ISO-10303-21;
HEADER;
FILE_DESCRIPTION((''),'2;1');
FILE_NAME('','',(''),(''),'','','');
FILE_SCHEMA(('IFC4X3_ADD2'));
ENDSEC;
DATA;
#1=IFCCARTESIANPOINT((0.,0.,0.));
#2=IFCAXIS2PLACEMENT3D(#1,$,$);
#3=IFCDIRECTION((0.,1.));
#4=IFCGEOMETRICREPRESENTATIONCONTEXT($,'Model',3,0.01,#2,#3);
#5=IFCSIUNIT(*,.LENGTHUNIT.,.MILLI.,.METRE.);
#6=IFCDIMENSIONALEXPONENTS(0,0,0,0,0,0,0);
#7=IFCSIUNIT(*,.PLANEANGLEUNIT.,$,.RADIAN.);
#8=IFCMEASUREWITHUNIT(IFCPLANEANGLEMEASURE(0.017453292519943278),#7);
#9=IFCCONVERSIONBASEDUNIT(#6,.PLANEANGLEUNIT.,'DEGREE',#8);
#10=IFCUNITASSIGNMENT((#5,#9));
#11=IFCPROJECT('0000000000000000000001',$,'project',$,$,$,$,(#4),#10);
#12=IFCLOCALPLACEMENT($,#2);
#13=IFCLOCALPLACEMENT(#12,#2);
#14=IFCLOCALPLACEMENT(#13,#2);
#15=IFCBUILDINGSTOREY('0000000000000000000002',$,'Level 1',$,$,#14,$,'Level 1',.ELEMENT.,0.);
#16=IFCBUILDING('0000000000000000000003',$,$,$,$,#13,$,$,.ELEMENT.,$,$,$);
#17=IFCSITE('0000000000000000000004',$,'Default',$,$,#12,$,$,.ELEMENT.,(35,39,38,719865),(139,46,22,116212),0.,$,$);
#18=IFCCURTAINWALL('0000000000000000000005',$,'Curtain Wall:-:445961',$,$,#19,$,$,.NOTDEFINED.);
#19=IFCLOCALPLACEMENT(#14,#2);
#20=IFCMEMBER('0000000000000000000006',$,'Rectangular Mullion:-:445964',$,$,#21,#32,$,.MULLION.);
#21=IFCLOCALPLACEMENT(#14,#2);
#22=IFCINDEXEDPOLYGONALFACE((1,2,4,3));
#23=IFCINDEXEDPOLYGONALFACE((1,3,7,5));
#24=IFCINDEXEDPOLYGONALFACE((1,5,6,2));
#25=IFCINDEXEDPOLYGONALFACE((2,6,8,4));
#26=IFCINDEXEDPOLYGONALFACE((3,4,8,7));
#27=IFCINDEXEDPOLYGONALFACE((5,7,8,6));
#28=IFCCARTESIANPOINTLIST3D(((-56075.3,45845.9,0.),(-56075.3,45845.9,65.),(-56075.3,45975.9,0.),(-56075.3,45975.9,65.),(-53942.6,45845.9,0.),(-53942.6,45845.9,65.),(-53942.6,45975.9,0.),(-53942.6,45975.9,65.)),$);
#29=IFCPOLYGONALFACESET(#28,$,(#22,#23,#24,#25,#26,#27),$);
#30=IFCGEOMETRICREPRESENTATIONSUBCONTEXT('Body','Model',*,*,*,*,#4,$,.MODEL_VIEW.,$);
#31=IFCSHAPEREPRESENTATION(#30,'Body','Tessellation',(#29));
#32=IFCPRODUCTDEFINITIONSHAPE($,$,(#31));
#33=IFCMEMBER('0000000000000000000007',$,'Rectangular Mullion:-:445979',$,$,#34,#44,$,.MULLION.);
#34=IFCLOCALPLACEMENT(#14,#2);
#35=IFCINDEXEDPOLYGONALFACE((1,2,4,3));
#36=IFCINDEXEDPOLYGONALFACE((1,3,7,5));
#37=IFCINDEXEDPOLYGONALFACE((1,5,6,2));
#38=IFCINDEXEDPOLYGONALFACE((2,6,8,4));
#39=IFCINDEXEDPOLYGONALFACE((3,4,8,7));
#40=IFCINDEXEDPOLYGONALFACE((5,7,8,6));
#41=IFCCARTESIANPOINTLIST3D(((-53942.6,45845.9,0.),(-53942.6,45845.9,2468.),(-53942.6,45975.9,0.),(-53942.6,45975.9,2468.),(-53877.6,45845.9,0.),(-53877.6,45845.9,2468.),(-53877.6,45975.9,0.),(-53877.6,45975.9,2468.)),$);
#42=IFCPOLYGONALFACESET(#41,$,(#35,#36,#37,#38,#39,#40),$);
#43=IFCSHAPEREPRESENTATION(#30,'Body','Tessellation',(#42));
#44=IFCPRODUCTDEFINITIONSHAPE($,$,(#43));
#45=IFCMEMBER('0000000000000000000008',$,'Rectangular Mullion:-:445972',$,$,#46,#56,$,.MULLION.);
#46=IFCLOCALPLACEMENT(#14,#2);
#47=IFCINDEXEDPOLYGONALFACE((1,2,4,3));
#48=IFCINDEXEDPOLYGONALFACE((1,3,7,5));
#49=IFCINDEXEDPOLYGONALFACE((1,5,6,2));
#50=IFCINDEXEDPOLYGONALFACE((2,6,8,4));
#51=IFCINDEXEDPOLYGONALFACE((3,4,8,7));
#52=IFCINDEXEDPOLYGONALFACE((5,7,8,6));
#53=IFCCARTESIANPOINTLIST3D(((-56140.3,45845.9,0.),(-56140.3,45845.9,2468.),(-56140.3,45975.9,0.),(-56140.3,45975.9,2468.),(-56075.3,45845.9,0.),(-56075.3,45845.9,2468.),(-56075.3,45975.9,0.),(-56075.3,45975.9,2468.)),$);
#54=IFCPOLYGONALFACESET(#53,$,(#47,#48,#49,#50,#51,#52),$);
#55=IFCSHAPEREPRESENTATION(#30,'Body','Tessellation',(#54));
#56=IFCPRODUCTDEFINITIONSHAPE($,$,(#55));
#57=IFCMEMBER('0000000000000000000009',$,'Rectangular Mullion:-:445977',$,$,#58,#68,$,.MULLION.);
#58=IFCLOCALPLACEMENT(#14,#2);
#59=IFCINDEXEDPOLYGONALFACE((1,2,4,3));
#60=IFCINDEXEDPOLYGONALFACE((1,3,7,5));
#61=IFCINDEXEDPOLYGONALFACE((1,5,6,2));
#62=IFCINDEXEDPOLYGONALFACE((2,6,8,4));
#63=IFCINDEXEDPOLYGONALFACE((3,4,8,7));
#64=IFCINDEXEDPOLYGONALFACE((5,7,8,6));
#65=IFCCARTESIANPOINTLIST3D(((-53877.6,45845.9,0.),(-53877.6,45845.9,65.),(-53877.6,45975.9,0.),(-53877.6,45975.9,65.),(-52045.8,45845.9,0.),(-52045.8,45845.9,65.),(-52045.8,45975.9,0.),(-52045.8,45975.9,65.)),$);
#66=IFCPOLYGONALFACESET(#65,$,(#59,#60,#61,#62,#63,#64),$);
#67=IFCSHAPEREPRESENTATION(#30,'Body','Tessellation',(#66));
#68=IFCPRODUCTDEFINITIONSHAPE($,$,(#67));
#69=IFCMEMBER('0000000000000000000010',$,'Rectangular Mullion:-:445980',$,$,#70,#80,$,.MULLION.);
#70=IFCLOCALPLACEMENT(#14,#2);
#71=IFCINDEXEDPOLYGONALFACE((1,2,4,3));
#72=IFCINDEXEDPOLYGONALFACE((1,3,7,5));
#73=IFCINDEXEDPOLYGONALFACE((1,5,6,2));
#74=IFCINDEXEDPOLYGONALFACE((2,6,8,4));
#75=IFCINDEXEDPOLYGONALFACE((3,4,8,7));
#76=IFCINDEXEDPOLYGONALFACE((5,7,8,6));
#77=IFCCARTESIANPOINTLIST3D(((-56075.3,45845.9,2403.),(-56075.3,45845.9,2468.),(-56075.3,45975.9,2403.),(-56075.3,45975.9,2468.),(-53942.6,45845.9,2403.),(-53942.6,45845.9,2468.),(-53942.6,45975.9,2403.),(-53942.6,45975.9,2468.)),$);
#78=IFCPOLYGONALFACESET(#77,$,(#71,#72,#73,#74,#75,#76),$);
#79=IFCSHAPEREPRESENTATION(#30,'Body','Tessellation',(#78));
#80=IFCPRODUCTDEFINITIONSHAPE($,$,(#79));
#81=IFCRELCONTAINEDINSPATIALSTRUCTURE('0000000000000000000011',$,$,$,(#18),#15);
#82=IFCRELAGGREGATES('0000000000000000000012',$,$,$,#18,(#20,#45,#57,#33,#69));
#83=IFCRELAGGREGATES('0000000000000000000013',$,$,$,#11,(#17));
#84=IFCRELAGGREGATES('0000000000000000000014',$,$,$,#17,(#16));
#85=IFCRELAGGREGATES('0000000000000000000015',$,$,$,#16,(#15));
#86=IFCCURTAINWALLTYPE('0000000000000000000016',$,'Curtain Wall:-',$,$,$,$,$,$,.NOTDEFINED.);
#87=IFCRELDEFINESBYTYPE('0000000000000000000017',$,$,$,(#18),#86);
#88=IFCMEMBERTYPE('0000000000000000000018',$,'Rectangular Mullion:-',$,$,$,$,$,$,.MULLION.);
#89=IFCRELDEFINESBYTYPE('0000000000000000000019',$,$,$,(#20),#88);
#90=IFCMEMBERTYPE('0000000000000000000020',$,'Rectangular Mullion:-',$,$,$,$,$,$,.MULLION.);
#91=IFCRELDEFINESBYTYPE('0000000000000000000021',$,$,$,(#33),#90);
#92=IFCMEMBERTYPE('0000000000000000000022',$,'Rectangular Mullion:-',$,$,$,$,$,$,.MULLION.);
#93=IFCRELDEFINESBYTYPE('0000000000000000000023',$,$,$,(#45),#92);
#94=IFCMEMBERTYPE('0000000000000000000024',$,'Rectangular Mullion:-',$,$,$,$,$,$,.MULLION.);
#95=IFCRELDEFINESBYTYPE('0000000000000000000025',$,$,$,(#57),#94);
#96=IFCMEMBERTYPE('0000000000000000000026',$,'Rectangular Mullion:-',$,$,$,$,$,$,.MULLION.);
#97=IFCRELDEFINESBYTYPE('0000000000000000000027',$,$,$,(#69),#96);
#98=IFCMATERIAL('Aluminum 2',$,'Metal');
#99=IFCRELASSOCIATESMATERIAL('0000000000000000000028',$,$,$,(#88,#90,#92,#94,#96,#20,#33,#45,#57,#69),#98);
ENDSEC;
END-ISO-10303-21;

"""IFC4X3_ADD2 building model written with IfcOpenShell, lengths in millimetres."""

from ifc_helpers import new_model, entity, si_unit, converted_unit, direction, frame, frame_2d, origin, origin_2d_with_axis, place, context, subcontext, project, spatial, rectangle, extrude, source, transform, mapped, material, material_profile, profile_set, profile_usage, type_object, type_shapes, element, aggregate, save


model = new_model("IFC4X3_ADD2")

# Units and contexts
model_context = context("Model", 3, precision=0.01, world=origin(), true_north=direction((0.0, 1.0)))
body_context = subcontext(model_context, "Body", "Model", "MODEL_VIEW")
ifc_project = project(units=[si_unit("LENGTHUNIT", "METRE", prefix="MILLI"), converted_unit("PLANEANGLEUNIT", "DEGREE", entity("IfcPlaneAngleMeasure", 0.017453292519943278), si_unit("PLANEANGLEUNIT", "RADIAN"), dimensions=[0, 0, 0, 0, 0, 0, 0])], contexts=[model_context])

# Site, building, storey
site_placement = place(None, origin())
site = spatial("IfcSite", under=ifc_project, at=site_placement, Name="Default", CompositionType="ELEMENT", RefLatitude=(35, 39, 38, 719865), RefLongitude=(139, 46, 22, 116212), RefElevation=0.0)
building_placement = place(site_placement, origin())
building = spatial("IfcBuilding", under=site, at=building_placement, CompositionType="ELEMENT")
storey_placement = place(building_placement, origin())
storey = spatial("IfcBuildingStorey", under=building, at=storey_placement, Name="Level 1", LongName="Level 1", CompositionType="ELEMENT", Elevation=0.0)

# Curtain wall, members
curtain_wall_type = type_object("IfcCurtainWallType", Name="Curtain Wall:-", PredefinedType="NOTDEFINED")
curtain_wall_placement = place(storey_placement, origin())
curtain_wall = element("IfcCurtainWall", 1, at=curtain_wall_placement, inside=storey, type_object=curtain_wall_type, Name="Curtain Wall:-:445961", PredefinedType="NOTDEFINED")
ifc_material_1 = material(Name="Aluminum 2", Category="Metal")
ifc_material_profile = material_profile(ifc_material_1, rectangle(XDim=65.0, YDim=130.0, at=origin_2d_with_axis()), Name="-")
ifc_profile_set = profile_set([ifc_material_profile], Name="-")
ifc_profile_usage = profile_usage(ifc_profile_set)
member_type_1 = type_object("IfcMemberType", Name="Rectangular Mullion:-", PredefinedType="MULLION", material=ifc_profile_set)
shared_shape_1 = source(origin(), body_context, "Body", "SweptSolid", [
    extrude(rectangle(XDim=65.0, YDim=130.0, at=origin_2d_with_axis()), frame((-32.5, 0.0, -2132.6), z_axis=(0.0, 0.0, 1.0), x_axis=(-1.0, 0.0, 0.0)), (0.0, 0.0, 1.0), 2132.6),
])
type_shapes(member_type_1, [shared_shape_1])
member_1_placement = place(curtain_wall_placement, frame((-56075.3, 45910.9, 0.0), z_axis=(-1.0, 0.0, 0.0), x_axis=(0.0, 0.0, -1.0)))
member_1 = element("IfcMember", 2, at=member_1_placement, type_object=member_type_1, material=ifc_profile_usage, Name="Rectangular Mullion:-:445964", PredefinedType="MULLION", context=body_context, shape_type="MappedRepresentation", body=[
    mapped(shared_shape_1, transform((0.0, 0.0, 0.0), scale=1.0)),
])
member_type_2 = type_object("IfcMemberType", Name="Rectangular Mullion:-", PredefinedType="MULLION", material=ifc_profile_set)
shared_shape_2 = source(origin(), body_context, "Body", "SweptSolid", [
    extrude(rectangle(XDim=65.0, YDim=130.0, at=frame_2d((0.0, 0.0), x_axis=(1.0, 0.0))), frame((0.0, 0.0, -2468.0), z_axis=(0.0, 0.0, 1.0), x_axis=(-1.0, 0.0, 0.0)), (0.0, 0.0, 1.0), 2468.0),
])
type_shapes(member_type_2, [shared_shape_2])
member_2_placement = place(curtain_wall_placement, frame((-53910.1, 45910.9, 0.0), z_axis=(0.0, 0.0, -1.0), x_axis=(1.0, 0.0, 0.0)))
member_2 = element("IfcMember", 3, at=member_2_placement, type_object=member_type_2, material=ifc_profile_usage, Name="Rectangular Mullion:-:445979", PredefinedType="MULLION", context=body_context, shape_type="MappedRepresentation", body=[
    mapped(shared_shape_2, transform((0.0, 0.0, 0.0), scale=1.0)),
])
member_type_3 = type_object("IfcMemberType", Name="Rectangular Mullion:-", PredefinedType="MULLION", material=ifc_profile_set)
shared_shape_3 = source(origin(), body_context, "Body", "SweptSolid", [
    extrude(rectangle(XDim=65.0, YDim=130.0, at=frame_2d((0.0, 0.0), x_axis=(1.0, 0.0))), frame((-32.5, 0.0, -2468.0), z_axis=(0.0, 0.0, 1.0), x_axis=(-1.0, 0.0, 0.0)), (0.0, 0.0, 1.0), 2468.0),
])
type_shapes(member_type_3, [shared_shape_3])
member_3_placement = place(curtain_wall_placement, frame((-56140.3, 45910.9, 2468.0), z_axis=(0.0, 0.0, 1.0), x_axis=(-1.0, 0.0, 0.0)))
member_3 = element("IfcMember", 4, at=member_3_placement, type_object=member_type_3, material=ifc_profile_usage, Name="Rectangular Mullion:-:445972", PredefinedType="MULLION", context=body_context, shape_type="MappedRepresentation", body=[
    mapped(shared_shape_3, transform((0.0, 0.0, 0.0), scale=1.0)),
])
member_type_4 = type_object("IfcMemberType", Name="Rectangular Mullion:-", PredefinedType="MULLION", material=ifc_profile_set)
shared_shape_4 = source(origin(), body_context, "Body", "SweptSolid", [
    extrude(rectangle(XDim=65.0, YDim=130.0, at=frame_2d((0.0, 0.0), x_axis=(1.0, 0.0))), frame((-32.5, 0.0, -1831.9), z_axis=(0.0, 0.0, 1.0), x_axis=(-1.0, 0.0, 0.0)), (0.0, 0.0, 1.0), 1831.9),
])
type_shapes(member_type_4, [shared_shape_4])
member_4_placement = place(curtain_wall_placement, frame((-53877.6, 45910.9, 0.0), z_axis=(-1.0, 0.0, 0.0), x_axis=(0.0, 0.0, -1.0)))
member_4 = element("IfcMember", 5, at=member_4_placement, type_object=member_type_4, material=ifc_profile_usage, Name="Rectangular Mullion:-:445977", PredefinedType="MULLION", context=body_context, shape_type="MappedRepresentation", body=[
    mapped(shared_shape_4, transform((0.0, 0.0, 0.0), scale=1.0)),
])
member_type_5 = type_object("IfcMemberType", Name="Rectangular Mullion:-", PredefinedType="MULLION", material=ifc_profile_set)
shared_shape_5 = source(origin(), body_context, "Body", "SweptSolid", [
    extrude(rectangle(XDim=65.0, YDim=130.0, at=origin_2d_with_axis()), frame((0.0, 0.0, -2132.6), z_axis=(0.0, 0.0, 1.0), x_axis=(-1.0, 0.0, 0.0)), (0.0, 0.0, 1.0), 2132.6),
])
type_shapes(member_type_5, [shared_shape_5])
member_5_placement = place(curtain_wall_placement, frame((-53942.6, 45910.9, 2435.5), z_axis=(1.0, 0.0, 0.0), x_axis=(0.0, 0.0, 1.0)))
member_5 = element("IfcMember", 6, at=member_5_placement, type_object=member_type_5, material=ifc_profile_usage, Name="Rectangular Mullion:-:445980", PredefinedType="MULLION", context=body_context, shape_type="MappedRepresentation", body=[
    mapped(shared_shape_5, transform((0.0, 0.0, 0.0), scale=1.0)),
])
aggregate(curtain_wall, [member_1, member_3, member_4, member_2, member_5])

save(model, "model.ifc")
